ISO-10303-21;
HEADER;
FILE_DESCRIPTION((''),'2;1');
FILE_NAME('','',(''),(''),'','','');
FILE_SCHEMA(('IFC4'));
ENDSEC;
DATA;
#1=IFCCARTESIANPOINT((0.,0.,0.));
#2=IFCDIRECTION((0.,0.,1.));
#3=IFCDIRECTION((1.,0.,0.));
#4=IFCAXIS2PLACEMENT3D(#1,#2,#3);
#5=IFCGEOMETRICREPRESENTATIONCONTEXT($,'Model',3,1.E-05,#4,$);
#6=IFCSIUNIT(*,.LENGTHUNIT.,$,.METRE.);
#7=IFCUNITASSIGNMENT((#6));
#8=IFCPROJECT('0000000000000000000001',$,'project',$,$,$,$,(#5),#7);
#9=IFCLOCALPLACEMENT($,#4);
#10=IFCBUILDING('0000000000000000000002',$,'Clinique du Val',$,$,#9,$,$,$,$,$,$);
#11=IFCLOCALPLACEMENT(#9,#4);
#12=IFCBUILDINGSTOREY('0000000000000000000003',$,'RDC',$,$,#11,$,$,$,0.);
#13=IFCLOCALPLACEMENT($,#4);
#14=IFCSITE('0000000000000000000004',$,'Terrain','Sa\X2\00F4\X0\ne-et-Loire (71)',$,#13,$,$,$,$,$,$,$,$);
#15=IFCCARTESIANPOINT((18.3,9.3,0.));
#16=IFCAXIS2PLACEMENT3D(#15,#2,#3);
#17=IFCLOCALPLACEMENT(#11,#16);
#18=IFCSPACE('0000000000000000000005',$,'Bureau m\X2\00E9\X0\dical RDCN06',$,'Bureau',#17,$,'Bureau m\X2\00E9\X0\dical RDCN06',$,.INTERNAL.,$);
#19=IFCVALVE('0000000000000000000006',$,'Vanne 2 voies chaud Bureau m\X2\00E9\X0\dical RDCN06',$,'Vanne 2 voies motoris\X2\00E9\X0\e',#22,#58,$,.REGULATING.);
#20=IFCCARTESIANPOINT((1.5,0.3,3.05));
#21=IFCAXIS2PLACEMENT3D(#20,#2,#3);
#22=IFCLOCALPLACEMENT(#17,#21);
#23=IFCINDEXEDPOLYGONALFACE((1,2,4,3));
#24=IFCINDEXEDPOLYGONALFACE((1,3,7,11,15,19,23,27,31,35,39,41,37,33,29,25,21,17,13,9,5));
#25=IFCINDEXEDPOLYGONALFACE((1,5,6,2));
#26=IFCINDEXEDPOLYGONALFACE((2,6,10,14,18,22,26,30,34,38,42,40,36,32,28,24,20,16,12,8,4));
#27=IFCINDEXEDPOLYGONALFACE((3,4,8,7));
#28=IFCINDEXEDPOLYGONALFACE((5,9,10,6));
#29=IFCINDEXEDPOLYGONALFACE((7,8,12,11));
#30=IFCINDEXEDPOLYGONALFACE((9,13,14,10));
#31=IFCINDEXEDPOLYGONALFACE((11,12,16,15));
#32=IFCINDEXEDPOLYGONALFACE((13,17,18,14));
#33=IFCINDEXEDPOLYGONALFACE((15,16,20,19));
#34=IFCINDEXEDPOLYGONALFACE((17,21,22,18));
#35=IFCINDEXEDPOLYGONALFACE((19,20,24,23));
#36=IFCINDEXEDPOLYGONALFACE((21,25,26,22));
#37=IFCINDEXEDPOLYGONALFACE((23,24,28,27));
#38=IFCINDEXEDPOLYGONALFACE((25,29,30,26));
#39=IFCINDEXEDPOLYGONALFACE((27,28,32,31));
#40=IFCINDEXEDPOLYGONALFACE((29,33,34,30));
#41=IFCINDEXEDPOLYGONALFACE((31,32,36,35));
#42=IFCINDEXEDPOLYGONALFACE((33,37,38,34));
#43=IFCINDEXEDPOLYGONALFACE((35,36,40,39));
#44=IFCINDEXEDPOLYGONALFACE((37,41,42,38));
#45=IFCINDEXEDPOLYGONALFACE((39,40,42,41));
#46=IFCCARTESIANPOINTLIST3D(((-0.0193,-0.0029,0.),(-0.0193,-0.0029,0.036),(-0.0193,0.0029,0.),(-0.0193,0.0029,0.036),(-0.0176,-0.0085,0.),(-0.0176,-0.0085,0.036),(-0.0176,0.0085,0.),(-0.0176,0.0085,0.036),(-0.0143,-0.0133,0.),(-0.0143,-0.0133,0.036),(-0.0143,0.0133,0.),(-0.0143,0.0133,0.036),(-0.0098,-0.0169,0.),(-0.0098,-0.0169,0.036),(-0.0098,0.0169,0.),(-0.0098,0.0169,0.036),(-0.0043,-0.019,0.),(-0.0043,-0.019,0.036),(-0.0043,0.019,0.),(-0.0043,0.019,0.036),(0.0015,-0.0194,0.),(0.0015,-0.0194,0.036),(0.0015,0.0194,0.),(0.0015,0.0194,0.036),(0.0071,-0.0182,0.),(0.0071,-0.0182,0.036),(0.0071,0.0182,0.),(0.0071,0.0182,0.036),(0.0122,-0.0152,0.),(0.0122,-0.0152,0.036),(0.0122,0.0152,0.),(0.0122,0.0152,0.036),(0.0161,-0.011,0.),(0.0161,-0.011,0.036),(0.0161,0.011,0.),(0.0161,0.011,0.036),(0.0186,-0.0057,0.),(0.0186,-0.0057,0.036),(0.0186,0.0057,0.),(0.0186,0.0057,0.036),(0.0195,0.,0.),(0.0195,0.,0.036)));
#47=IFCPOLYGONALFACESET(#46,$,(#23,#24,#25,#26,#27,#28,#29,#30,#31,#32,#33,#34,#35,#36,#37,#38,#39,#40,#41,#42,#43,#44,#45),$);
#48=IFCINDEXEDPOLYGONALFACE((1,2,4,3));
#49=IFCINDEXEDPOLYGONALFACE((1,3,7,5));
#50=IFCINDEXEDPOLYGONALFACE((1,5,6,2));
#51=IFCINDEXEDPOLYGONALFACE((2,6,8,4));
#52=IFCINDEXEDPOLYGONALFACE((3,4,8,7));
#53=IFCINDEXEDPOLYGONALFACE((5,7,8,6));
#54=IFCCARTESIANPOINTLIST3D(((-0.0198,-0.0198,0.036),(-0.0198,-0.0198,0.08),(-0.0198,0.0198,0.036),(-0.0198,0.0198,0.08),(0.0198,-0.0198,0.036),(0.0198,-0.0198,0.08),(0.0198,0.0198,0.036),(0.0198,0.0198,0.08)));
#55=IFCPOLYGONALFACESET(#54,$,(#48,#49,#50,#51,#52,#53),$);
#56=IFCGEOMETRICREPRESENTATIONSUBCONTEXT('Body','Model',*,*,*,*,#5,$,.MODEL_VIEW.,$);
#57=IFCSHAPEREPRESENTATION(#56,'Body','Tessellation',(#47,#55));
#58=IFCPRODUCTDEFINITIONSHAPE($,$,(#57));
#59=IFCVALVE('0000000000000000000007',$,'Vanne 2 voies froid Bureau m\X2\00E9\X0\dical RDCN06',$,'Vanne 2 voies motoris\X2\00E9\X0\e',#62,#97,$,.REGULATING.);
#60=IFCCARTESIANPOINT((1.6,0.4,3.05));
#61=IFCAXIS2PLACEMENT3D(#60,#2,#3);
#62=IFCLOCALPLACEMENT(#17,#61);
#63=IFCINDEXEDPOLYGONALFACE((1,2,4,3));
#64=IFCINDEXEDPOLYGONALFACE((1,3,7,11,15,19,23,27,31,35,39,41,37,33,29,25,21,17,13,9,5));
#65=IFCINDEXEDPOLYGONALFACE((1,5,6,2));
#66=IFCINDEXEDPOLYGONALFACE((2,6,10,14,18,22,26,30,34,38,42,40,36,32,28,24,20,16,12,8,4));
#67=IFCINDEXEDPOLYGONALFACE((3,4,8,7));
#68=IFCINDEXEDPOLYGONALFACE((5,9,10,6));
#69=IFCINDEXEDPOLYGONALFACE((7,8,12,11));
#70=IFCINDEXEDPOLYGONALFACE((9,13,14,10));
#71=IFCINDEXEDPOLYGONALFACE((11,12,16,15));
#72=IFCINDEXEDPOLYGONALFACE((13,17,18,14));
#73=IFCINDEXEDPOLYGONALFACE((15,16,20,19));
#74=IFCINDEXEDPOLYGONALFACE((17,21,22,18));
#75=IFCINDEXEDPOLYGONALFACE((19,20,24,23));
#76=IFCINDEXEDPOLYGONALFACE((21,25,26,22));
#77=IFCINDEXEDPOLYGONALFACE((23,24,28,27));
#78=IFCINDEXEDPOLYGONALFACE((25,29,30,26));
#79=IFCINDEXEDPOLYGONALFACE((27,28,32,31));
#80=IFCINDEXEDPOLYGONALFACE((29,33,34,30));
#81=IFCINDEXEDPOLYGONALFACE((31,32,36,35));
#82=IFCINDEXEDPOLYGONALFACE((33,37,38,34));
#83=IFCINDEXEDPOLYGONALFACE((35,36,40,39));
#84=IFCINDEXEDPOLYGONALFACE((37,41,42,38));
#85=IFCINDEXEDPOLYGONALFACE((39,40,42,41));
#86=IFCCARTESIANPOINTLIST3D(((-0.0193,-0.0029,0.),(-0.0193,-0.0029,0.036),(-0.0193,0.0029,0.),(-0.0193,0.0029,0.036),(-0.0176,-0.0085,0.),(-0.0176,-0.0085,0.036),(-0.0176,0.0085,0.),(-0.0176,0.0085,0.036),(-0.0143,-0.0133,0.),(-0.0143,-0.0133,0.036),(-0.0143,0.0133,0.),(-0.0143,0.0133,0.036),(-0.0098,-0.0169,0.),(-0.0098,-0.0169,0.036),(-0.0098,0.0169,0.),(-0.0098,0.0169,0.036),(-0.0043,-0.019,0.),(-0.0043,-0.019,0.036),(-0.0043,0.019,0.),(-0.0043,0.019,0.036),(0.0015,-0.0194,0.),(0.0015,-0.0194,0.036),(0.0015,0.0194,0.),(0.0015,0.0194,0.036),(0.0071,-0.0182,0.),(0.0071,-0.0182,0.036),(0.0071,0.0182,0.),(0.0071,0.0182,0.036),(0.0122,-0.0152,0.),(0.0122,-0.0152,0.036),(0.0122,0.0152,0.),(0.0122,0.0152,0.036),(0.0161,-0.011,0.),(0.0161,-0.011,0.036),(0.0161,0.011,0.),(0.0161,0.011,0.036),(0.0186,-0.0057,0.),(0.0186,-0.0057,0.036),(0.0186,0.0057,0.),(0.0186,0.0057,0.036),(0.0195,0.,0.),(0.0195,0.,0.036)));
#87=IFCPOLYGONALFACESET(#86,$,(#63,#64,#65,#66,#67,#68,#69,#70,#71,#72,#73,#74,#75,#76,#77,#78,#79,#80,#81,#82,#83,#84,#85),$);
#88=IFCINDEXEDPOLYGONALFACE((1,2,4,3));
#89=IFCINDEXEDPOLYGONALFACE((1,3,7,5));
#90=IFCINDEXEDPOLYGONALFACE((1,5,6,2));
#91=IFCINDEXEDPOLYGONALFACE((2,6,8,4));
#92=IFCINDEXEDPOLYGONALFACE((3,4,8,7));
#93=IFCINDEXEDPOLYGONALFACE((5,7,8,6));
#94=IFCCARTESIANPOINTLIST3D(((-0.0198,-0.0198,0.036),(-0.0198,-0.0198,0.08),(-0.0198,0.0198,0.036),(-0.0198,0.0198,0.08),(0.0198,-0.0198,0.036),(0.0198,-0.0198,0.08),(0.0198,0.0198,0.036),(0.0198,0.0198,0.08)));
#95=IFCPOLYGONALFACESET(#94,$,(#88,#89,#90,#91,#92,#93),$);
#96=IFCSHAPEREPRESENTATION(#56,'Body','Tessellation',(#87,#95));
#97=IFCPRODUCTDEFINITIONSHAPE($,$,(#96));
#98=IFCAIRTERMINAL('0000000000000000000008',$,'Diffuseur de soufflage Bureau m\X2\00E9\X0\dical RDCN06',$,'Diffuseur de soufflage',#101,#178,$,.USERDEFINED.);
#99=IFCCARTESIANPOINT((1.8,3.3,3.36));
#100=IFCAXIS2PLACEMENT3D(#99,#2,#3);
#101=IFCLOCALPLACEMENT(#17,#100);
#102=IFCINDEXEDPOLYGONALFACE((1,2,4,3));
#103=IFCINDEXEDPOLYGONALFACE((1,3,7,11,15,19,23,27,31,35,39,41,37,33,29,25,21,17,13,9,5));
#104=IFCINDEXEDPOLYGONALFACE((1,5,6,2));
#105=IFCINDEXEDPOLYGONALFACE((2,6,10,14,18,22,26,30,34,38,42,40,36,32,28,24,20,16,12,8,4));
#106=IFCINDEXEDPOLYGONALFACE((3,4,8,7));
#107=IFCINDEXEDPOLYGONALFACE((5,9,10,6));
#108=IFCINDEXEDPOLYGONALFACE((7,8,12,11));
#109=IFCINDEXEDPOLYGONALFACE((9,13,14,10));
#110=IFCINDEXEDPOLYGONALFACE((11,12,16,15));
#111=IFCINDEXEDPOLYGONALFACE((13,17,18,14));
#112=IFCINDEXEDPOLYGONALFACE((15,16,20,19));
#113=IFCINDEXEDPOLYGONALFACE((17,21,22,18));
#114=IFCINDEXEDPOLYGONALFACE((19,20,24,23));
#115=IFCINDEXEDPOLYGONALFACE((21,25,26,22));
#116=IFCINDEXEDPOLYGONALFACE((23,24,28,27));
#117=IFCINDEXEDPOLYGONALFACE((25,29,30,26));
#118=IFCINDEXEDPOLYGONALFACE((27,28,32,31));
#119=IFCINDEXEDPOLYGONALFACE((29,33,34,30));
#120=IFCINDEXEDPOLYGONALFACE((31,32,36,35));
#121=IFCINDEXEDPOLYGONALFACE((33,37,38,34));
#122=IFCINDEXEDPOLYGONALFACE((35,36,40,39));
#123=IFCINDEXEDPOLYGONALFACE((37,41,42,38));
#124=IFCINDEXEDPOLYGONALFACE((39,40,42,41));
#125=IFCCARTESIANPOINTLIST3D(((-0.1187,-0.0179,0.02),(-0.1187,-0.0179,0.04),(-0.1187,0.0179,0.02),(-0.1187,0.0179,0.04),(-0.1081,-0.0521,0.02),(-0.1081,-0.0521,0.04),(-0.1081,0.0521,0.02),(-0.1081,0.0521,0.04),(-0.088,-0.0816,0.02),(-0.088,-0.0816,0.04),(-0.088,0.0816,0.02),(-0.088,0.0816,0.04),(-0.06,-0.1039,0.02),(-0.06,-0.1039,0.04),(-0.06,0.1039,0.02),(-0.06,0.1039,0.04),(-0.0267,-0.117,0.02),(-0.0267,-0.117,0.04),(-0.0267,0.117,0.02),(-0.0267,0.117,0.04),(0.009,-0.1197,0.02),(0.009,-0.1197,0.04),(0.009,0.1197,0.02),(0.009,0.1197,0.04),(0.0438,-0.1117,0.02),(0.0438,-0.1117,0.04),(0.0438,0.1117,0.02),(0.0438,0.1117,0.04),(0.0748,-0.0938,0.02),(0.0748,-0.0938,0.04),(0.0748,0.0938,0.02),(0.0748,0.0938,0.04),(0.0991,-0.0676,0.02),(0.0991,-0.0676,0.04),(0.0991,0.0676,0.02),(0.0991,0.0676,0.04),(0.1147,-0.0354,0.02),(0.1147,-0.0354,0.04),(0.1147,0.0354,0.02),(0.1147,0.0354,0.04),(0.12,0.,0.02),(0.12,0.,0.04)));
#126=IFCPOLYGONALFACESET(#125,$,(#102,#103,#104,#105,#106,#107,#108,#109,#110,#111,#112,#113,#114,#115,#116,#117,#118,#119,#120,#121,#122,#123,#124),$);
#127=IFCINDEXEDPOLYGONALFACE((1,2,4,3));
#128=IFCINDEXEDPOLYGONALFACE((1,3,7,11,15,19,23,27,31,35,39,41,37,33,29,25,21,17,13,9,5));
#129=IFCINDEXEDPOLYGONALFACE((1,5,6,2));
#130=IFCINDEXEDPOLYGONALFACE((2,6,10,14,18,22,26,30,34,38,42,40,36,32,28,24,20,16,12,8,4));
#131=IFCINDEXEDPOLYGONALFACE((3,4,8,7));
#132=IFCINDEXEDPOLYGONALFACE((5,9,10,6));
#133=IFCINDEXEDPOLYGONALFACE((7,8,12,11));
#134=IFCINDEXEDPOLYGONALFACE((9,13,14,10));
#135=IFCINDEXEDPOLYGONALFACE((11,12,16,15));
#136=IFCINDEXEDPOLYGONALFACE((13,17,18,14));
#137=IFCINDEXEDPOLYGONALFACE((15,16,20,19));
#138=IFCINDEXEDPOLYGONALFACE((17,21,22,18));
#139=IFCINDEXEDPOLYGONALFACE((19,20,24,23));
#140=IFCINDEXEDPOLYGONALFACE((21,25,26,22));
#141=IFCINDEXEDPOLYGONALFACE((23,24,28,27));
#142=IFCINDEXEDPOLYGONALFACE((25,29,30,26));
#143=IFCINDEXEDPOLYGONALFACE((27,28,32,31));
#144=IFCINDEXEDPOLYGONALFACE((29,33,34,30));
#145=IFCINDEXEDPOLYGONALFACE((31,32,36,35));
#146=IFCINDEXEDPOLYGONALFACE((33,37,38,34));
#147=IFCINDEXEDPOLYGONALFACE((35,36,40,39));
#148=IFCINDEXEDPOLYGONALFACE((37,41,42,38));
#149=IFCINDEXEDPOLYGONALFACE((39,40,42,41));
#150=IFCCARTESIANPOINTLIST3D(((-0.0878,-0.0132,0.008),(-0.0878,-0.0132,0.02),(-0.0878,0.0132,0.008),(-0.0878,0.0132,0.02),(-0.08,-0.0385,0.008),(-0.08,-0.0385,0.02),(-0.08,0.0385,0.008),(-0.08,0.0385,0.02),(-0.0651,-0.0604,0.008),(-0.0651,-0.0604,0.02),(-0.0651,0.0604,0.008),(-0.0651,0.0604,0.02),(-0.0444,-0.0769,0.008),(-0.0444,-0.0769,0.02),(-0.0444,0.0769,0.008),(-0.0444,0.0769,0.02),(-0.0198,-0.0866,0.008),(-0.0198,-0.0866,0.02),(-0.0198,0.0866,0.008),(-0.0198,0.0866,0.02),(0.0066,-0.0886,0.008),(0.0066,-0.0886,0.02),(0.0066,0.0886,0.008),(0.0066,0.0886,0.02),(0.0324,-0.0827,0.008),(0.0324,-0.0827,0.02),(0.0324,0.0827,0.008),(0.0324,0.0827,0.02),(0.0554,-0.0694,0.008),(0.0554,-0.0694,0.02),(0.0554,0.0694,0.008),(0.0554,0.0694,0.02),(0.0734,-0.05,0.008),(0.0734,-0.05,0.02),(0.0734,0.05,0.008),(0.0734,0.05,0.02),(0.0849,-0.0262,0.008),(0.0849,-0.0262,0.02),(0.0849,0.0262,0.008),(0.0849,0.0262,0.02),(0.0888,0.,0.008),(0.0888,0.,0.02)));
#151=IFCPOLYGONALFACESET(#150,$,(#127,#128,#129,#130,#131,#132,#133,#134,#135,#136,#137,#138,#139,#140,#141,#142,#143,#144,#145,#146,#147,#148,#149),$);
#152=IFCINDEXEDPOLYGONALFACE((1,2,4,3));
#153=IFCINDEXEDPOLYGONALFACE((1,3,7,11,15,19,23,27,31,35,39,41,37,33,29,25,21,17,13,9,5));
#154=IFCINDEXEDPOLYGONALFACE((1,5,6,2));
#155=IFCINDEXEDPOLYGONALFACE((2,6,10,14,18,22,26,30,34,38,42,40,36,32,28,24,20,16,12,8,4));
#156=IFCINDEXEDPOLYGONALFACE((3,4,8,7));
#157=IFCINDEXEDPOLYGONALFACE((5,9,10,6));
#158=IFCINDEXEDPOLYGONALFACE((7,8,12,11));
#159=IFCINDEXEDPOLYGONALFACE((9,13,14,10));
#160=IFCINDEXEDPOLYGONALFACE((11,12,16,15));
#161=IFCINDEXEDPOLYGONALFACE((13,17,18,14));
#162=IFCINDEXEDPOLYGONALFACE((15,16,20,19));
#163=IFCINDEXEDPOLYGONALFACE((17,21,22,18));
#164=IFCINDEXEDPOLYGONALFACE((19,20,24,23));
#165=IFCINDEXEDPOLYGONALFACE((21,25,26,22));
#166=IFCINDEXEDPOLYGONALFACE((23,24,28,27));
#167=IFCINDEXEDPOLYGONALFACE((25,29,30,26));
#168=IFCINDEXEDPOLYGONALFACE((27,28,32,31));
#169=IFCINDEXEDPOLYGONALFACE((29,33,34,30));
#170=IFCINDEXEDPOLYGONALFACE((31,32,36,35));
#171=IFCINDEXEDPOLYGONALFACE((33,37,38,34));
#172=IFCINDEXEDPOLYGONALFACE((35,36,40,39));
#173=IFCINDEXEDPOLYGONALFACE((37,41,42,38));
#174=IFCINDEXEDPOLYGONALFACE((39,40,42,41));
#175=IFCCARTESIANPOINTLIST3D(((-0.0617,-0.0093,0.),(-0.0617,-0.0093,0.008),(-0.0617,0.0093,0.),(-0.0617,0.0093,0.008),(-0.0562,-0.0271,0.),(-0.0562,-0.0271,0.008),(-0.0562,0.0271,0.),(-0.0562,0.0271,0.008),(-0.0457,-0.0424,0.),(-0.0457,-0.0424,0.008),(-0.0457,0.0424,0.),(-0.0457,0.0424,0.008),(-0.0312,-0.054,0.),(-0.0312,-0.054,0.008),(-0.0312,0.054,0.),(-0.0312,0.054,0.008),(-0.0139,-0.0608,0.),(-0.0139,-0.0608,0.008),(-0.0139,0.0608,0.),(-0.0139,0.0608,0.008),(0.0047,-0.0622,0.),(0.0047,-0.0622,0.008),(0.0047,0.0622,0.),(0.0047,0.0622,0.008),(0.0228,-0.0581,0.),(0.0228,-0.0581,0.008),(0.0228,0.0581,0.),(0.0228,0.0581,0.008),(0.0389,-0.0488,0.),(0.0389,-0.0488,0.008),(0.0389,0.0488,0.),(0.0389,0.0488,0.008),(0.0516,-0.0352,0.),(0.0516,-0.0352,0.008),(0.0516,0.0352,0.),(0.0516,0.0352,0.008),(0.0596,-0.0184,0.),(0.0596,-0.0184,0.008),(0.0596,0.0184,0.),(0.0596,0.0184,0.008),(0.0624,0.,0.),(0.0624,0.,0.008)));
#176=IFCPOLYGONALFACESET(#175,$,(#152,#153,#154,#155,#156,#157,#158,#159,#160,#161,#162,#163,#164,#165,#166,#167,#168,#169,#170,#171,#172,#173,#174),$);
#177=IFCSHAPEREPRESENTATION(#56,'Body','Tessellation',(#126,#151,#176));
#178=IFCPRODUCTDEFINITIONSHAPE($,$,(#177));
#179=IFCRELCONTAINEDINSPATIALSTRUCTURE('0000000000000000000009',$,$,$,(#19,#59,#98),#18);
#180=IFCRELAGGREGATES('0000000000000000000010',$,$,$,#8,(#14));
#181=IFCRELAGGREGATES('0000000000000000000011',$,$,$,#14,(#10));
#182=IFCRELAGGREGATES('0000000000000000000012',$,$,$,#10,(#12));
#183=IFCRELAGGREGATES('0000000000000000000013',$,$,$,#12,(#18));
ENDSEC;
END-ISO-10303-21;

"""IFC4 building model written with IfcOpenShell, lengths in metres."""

from ifc_helpers import new_model, si_unit, frame, frame_2d, origin_with_axes, place, context, subcontext, project, spatial, rectangle, circle, extrude, element, save


model = new_model("IFC4")

# Units and contexts
model_context = context("Model", 3, precision=1e-05, world=origin_with_axes())
body_context = subcontext(model_context, "Body", "Model", "MODEL_VIEW")
ifc_project = project(units=[si_unit("LENGTHUNIT", "METRE")], contexts=[model_context])

# Site, building, storey
site_placement = place(None, origin_with_axes())
site = spatial("IfcSite", under=ifc_project, at=site_placement, Name="Terrain", Description="Saône-et-Loire (71)")
building_placement = place(None, origin_with_axes())
building = spatial("IfcBuilding", under=site, at=building_placement, Name="Clinique du Val")
storey_placement = place(building_placement, origin_with_axes())
storey = spatial("IfcBuildingStorey", under=building, at=storey_placement, Name="RDC", Elevation=0.0)

# Shared definitions
space_1_placement = place(storey_placement, frame((18.3, 9.3, 0.0), z_axis=(0.0, 0.0, 1.0), x_axis=(1.0, 0.0, 0.0)))
space_1 = spatial("IfcSpace", under=storey, at=space_1_placement, Name="Bureau médical RDCN06", ObjectType="Bureau", LongName="Bureau médical RDCN06", PredefinedType="INTERNAL")

# Valves
for number, where, z_axis, x_axis, name in (
    (1, (1.5, 0.3, 3.05), (0.0, 0.0, 1.0), (1.0, 0.0, 0.0), "Vanne 2 voies chaud Bureau médical RDCN06"),
    (2, (1.6, 0.4, 3.05), (0.0, 0.0, 1.0), (1.0, 0.0, 0.0), "Vanne 2 voies froid Bureau médical RDCN06"),
):
    element("IfcValve", number, at=place(space_1_placement, frame(where, z_axis=z_axis, x_axis=x_axis)), inside=space_1, Name=name, ObjectType="Vanne 2 voies motorisée", PredefinedType="REGULATING", context=body_context, shape_type="SweptSolid", body=[
        extrude(circle(Radius=0.0195), origin_with_axes(), (0.0, 0.0, 1.0), 0.036),
        extrude(rectangle(XDim=0.0396, YDim=0.0396, at=frame_2d((0.0198, 0.0198))), frame((-0.0198, -0.0198, 0.036), z_axis=(0.0, 0.0, 1.0), x_axis=(1.0, 0.0, 0.0)), (0.0, 0.0, 1.0), 0.044),
    ])

# Air terminal
air_terminal_1_placement = place(space_1_placement, frame((1.8, 3.3, 3.36), z_axis=(0.0, 0.0, 1.0), x_axis=(1.0, 0.0, 0.0)))
element("IfcAirTerminal", 3, at=air_terminal_1_placement, inside=space_1, Name="Diffuseur de soufflage Bureau médical RDCN06", ObjectType="Diffuseur de soufflage", PredefinedType="USERDEFINED", context=body_context, shape_type="SweptSolid", body=[
    extrude(circle(Radius=0.12), frame((0.0, 0.0, 0.02), z_axis=(0.0, 0.0, 1.0), x_axis=(1.0, 0.0, 0.0)), (0.0, 0.0, 1.0), 0.02),
    extrude(circle(Radius=0.0888), frame((0.0, 0.0, 0.008), z_axis=(0.0, 0.0, 1.0), x_axis=(1.0, 0.0, 0.0)), (0.0, 0.0, 1.0), 0.012),
    extrude(circle(Radius=0.0624), origin_with_axes(), (0.0, 0.0, 1.0), 0.008),
])

save(model, "model.ifc")
